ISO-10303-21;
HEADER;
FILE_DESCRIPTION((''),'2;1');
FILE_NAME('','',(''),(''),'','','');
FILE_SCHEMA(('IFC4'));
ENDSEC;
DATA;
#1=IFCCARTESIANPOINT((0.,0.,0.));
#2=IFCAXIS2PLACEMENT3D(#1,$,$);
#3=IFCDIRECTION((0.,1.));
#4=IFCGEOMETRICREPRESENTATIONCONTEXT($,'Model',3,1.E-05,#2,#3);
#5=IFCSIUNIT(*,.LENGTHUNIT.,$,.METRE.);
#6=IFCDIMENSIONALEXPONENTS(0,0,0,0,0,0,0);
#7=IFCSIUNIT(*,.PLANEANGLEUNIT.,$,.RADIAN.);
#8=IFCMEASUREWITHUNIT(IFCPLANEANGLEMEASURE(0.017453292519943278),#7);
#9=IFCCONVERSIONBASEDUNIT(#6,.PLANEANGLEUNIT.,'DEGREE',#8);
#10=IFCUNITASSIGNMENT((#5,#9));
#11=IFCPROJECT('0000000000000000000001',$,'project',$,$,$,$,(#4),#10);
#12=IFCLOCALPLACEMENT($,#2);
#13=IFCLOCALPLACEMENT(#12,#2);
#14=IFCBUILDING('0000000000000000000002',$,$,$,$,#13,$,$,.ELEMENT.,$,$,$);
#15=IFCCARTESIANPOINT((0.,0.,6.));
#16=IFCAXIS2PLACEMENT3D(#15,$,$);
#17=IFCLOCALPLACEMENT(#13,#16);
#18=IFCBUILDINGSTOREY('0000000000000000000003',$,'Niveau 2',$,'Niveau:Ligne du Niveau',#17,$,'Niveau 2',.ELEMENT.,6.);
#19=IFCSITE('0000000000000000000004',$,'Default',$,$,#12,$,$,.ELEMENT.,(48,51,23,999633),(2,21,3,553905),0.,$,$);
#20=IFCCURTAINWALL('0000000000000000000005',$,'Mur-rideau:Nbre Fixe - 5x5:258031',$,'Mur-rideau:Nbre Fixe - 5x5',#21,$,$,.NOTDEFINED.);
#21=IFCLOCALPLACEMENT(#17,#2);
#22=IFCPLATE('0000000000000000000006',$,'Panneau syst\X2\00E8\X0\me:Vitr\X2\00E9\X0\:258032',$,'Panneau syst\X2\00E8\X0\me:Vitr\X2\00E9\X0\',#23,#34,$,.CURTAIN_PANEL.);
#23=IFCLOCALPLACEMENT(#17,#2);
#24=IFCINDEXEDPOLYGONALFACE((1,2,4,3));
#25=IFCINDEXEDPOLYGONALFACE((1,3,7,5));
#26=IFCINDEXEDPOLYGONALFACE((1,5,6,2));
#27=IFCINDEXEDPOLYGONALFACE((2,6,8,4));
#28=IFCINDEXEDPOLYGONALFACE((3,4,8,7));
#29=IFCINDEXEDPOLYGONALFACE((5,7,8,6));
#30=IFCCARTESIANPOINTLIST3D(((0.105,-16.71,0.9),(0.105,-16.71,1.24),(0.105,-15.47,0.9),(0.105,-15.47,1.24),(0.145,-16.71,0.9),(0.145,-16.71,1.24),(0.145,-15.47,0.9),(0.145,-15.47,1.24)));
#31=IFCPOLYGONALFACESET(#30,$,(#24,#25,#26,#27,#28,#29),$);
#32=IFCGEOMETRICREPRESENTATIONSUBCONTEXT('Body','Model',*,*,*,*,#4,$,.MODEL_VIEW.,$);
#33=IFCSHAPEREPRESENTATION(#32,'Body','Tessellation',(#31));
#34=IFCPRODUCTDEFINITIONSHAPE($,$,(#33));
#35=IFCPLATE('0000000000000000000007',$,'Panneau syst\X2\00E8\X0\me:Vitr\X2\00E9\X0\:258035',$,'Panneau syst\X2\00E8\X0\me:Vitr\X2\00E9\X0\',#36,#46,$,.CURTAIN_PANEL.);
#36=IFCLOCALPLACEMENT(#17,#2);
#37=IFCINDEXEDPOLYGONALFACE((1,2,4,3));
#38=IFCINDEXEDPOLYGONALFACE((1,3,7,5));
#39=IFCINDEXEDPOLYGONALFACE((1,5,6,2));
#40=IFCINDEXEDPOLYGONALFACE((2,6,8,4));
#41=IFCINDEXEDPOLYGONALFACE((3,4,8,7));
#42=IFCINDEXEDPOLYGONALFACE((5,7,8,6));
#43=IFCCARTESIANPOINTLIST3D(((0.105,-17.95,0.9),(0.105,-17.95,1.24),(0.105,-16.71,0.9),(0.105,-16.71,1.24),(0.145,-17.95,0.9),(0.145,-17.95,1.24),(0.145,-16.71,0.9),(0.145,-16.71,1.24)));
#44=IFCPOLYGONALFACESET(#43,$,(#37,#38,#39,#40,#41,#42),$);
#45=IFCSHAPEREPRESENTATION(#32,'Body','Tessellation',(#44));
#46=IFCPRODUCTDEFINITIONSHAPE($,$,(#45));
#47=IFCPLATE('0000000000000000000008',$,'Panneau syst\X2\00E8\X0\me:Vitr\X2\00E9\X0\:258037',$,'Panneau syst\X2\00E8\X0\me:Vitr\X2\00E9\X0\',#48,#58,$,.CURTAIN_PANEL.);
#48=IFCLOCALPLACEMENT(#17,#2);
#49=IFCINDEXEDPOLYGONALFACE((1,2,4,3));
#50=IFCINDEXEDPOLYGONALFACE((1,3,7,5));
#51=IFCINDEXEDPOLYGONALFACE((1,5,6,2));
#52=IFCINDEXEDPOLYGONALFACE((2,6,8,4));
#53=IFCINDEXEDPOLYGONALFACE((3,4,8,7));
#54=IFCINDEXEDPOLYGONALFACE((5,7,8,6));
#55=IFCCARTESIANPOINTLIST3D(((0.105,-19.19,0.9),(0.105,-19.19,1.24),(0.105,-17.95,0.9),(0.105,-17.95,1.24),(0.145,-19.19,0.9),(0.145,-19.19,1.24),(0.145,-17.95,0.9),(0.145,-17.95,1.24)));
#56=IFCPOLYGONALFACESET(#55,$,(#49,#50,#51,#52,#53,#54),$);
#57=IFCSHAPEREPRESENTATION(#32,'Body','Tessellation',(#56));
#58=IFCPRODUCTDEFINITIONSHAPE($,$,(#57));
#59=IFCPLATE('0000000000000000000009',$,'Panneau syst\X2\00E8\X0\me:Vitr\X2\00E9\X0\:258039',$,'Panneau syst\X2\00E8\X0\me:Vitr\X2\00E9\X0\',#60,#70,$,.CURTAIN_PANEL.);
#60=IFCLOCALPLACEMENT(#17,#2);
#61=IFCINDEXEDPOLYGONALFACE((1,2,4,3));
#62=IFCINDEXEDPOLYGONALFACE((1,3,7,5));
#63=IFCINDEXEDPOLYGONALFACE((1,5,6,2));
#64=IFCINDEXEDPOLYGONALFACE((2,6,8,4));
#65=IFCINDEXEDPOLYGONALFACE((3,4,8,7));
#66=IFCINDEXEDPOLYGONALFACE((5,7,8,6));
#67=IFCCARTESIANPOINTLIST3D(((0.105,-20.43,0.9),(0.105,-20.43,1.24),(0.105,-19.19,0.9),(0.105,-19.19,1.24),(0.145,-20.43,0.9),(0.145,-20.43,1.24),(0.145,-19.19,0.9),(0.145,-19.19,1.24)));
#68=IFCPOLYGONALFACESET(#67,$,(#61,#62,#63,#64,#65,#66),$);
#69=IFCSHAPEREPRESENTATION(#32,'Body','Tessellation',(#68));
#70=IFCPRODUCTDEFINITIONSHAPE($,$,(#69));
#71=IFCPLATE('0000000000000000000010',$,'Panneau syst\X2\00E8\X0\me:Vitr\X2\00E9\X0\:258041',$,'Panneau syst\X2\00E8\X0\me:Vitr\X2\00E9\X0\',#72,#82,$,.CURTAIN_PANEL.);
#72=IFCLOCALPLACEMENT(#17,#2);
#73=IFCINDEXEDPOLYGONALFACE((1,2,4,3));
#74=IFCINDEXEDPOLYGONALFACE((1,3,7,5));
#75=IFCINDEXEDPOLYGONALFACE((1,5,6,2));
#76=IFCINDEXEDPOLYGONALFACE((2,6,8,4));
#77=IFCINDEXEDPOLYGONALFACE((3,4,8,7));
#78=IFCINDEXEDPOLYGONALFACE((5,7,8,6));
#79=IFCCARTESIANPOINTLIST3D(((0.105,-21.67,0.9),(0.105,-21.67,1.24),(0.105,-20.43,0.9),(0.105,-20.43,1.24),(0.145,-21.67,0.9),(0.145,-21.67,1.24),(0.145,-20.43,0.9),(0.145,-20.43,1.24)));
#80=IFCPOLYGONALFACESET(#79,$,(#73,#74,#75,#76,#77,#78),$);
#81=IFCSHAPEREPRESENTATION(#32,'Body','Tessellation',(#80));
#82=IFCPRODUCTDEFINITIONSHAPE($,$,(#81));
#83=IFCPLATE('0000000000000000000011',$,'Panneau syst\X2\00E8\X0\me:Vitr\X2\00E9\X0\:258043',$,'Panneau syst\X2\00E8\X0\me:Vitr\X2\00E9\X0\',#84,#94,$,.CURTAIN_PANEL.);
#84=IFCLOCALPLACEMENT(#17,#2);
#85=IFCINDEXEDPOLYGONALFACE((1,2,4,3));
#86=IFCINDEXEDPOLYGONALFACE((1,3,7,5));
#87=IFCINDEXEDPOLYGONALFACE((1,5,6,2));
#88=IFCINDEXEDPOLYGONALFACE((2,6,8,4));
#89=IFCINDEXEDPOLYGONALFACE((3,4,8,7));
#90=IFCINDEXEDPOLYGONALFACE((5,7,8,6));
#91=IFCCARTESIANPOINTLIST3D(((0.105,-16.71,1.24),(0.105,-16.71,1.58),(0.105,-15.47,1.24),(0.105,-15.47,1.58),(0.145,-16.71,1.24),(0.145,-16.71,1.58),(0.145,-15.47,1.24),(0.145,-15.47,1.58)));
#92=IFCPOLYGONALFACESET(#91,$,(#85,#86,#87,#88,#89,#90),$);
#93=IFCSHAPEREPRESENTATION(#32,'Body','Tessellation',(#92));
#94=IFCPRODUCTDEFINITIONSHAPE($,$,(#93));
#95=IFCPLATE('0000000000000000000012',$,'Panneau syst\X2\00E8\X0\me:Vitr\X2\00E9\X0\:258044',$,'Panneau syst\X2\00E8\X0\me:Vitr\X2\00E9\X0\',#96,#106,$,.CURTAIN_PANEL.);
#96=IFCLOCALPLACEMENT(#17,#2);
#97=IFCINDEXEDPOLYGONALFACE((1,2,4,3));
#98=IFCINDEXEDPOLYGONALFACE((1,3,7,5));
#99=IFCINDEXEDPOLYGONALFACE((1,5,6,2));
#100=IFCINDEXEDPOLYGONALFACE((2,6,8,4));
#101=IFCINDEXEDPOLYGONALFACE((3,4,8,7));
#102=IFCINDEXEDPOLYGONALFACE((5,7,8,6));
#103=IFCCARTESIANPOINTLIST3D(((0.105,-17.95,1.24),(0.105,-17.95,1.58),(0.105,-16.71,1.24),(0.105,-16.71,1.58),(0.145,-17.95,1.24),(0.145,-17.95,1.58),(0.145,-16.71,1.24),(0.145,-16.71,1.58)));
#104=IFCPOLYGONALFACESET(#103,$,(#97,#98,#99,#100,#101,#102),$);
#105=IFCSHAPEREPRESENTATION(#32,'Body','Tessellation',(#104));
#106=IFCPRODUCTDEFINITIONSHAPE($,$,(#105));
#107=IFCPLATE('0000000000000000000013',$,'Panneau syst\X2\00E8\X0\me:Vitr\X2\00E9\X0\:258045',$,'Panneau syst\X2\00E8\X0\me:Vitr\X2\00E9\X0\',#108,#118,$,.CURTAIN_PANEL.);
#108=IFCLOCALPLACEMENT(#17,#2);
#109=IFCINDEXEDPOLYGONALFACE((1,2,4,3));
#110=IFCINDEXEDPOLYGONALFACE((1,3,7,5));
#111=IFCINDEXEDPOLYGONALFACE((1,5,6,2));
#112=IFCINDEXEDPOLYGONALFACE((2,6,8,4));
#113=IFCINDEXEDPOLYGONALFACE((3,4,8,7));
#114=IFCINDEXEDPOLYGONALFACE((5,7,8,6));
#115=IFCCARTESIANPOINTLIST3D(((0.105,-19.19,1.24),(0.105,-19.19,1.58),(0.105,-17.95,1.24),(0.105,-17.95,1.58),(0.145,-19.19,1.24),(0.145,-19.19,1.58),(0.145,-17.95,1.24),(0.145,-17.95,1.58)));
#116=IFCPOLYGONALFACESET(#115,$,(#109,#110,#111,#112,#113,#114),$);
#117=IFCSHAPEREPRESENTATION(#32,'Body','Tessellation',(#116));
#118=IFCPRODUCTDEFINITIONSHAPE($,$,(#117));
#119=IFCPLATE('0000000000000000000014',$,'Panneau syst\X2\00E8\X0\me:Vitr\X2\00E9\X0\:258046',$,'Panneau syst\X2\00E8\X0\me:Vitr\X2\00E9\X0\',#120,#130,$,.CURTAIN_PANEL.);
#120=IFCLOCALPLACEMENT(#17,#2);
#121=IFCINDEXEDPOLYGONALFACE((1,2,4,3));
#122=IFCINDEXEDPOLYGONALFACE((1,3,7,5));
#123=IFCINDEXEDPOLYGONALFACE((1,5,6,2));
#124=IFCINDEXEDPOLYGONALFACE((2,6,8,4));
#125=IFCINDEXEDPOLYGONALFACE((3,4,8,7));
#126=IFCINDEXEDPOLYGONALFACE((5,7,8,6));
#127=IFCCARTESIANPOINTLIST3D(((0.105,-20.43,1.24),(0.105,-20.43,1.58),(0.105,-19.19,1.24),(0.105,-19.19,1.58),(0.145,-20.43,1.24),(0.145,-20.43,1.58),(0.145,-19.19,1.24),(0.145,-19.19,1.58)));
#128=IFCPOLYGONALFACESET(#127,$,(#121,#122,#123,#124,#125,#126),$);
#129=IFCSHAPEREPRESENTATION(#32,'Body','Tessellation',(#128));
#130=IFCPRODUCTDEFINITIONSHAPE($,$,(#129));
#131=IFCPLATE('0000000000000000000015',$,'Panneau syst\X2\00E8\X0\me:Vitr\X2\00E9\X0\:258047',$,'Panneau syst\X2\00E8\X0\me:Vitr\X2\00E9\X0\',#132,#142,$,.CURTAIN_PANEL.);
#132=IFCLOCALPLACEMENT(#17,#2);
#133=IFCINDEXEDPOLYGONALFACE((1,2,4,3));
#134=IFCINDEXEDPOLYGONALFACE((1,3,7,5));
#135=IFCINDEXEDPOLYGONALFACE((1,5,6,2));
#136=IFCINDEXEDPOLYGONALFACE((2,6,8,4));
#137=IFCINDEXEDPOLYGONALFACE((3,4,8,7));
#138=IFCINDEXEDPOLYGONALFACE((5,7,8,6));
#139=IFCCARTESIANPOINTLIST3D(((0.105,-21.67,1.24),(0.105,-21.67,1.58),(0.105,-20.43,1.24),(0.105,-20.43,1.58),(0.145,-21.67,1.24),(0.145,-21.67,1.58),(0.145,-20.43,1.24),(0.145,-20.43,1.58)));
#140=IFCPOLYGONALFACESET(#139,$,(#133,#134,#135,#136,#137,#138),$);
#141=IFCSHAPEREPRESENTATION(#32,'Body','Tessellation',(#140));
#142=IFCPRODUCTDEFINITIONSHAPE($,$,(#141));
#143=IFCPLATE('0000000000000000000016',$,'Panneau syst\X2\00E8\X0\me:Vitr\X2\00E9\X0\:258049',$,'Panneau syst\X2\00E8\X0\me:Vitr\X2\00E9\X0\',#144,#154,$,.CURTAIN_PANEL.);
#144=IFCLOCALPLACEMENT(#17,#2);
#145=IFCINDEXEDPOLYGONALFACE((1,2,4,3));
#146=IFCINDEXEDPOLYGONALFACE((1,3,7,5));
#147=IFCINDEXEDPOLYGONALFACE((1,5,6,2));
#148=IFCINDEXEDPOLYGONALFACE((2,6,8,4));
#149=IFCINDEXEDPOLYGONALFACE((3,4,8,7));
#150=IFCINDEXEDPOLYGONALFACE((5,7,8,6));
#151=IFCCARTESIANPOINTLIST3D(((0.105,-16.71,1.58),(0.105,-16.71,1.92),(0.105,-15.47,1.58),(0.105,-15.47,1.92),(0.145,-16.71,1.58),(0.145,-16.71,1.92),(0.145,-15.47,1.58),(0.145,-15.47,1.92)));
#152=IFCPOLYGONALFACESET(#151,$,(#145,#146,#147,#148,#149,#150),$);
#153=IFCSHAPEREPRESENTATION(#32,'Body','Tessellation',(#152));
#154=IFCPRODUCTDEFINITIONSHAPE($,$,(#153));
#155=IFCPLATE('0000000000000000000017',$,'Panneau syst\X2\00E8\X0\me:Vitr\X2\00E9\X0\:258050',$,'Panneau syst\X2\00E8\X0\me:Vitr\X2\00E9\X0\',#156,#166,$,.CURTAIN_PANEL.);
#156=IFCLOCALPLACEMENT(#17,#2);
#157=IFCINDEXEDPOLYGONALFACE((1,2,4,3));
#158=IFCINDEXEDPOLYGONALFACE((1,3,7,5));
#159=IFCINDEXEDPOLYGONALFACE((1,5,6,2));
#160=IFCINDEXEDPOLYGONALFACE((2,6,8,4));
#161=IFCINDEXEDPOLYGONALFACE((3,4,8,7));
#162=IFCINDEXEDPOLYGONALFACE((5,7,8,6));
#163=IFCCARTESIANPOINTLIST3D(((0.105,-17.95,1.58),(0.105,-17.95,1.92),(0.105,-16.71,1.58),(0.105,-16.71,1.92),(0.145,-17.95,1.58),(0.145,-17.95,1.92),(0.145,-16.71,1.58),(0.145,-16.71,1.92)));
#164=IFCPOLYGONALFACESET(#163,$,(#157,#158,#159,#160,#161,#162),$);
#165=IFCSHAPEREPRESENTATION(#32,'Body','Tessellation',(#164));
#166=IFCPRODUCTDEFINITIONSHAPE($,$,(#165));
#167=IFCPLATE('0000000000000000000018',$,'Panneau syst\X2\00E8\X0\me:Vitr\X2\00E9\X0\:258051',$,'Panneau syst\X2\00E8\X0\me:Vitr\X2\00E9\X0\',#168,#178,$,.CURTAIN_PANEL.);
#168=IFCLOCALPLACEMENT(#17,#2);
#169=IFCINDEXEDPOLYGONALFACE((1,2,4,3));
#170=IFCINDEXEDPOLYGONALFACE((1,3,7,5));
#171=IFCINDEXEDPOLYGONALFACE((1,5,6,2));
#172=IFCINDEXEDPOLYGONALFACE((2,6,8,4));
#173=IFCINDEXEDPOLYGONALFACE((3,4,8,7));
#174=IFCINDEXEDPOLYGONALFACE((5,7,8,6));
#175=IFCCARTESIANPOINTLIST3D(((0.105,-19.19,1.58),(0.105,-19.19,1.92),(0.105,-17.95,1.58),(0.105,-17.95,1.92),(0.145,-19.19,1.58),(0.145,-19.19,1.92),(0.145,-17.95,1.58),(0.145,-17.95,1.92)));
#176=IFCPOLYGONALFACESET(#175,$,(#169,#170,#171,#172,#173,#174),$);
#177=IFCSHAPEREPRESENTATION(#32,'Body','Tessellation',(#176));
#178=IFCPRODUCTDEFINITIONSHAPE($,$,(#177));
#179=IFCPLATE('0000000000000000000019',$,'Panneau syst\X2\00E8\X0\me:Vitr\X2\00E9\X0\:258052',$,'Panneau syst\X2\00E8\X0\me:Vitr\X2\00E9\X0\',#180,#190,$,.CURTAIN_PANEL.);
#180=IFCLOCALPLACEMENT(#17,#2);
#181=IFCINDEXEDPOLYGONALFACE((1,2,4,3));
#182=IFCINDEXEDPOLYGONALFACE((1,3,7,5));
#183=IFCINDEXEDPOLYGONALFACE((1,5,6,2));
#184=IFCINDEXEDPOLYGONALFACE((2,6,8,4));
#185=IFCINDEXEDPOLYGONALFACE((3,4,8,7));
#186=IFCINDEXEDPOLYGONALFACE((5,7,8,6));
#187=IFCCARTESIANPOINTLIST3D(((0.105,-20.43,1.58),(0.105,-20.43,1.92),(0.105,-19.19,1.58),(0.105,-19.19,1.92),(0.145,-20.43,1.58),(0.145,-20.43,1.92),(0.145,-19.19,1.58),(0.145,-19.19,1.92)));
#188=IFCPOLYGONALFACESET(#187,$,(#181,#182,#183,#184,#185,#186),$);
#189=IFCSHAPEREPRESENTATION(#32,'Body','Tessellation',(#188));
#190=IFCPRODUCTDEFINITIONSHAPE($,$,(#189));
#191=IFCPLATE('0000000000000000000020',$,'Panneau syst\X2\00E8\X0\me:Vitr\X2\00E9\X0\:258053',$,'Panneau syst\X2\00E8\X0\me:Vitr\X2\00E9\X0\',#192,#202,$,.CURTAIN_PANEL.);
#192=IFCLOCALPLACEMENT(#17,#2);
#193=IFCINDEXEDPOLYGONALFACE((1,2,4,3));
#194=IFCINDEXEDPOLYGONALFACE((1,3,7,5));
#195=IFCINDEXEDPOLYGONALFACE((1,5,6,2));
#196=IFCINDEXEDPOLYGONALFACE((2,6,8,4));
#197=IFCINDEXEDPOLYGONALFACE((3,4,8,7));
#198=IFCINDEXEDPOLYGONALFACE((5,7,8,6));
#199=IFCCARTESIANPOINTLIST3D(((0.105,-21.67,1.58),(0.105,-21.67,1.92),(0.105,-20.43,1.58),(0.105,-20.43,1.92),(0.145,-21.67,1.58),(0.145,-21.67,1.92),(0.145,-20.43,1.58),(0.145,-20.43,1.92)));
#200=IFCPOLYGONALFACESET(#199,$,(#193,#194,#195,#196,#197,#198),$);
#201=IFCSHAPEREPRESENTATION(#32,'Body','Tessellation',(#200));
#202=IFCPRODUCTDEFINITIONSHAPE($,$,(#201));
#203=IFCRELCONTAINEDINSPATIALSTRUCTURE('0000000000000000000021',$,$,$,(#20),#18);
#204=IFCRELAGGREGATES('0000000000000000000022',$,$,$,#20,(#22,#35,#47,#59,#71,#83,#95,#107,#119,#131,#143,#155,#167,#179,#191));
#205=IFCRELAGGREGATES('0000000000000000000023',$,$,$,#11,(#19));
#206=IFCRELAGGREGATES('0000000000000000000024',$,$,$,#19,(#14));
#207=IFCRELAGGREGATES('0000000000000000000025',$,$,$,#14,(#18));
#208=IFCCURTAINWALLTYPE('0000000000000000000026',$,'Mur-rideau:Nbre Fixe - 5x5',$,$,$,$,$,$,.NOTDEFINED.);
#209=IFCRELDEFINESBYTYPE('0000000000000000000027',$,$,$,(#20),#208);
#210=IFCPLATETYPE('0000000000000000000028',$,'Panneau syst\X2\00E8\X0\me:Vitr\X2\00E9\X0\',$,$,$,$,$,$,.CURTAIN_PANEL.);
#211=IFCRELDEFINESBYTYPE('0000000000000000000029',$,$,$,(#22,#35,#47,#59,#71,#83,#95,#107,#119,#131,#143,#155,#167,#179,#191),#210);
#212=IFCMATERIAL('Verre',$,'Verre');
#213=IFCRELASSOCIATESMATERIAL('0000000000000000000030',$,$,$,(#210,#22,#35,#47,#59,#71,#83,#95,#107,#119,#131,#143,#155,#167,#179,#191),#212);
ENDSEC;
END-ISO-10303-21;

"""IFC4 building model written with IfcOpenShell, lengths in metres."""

from ifc_helpers import new_model, entity, si_unit, converted_unit, direction, frame, origin, place, context, subcontext, project, spatial, indexed_curve, outline, extrude, source, transform, mapped, material, type_object, type_shapes, element, aggregate, save


model = new_model("IFC4")

# Units and contexts
model_context = context("Model", 3, precision=1e-05, world=origin(), true_north=direction((0.0, 1.0)))
body_context = subcontext(model_context, "Body", "Model", "MODEL_VIEW")
ifc_project = project(units=[si_unit("LENGTHUNIT", "METRE"), converted_unit("PLANEANGLEUNIT", "DEGREE", entity("IfcPlaneAngleMeasure", 0.017453292519943278), si_unit("PLANEANGLEUNIT", "RADIAN"), dimensions=[0, 0, 0, 0, 0, 0, 0])], contexts=[model_context])

# Site, building, storey
site_placement = place(None, origin())
site = spatial("IfcSite", under=ifc_project, at=site_placement, Name="Default", CompositionType="ELEMENT", RefLatitude=(48, 51, 23, 999633), RefLongitude=(2, 21, 3, 553905), RefElevation=0.0)
building_placement = place(site_placement, origin())
building = spatial("IfcBuilding", under=site, at=building_placement, CompositionType="ELEMENT")
storey_placement = place(building_placement, frame((0.0, 0.0, 6.0)))
storey = spatial("IfcBuildingStorey", under=building, at=storey_placement, Name="Niveau 2", ObjectType="Niveau:Ligne du Niveau", LongName="Niveau 2", CompositionType="ELEMENT", Elevation=6.0)

# Curtain wall, plates
curtain_wall_type = type_object("IfcCurtainWallType", Name="Mur-rideau:Nbre Fixe - 5x5", PredefinedType="NOTDEFINED")
curtain_wall_placement = place(storey_placement, frame((0.0, 0.0, -6.0)))
curtain_wall = element("IfcCurtainWall", 1, at=curtain_wall_placement, inside=storey, type_object=curtain_wall_type, Name="Mur-rideau:Nbre Fixe - 5x5:258031", ObjectType="Mur-rideau:Nbre Fixe - 5x5", PredefinedType="NOTDEFINED")
ifc_material_1 = material(Name="Verre", Category="Verre")
plate_type = type_object("IfcPlateType", Name="Panneau système:Vitré", PredefinedType="CURTAIN_PANEL", material=ifc_material_1)
shared_shape = source(origin(), body_context, "Body", "SweptSolid", [
    extrude(outline(indexed_curve([(-0.02, -0.62), (0.02, -0.62), (0.02, 0.62), (-0.02, 0.62), (-0.02, -0.62)], self_intersect=False)), frame((0.62, 0.02, 0.0), z_axis=(0.0, 0.0, 1.0), x_axis=(0.0, 1.0, 0.0)), (0.0, 0.0, 1.0), 0.34),
])
type_shapes(plate_type, [shared_shape])
plate_1_placement = place(curtain_wall_placement, frame((0.105, -15.47, 6.9), z_axis=(0.0, 0.0, 1.0), x_axis=(0.0, -1.0, 0.0)))
plate_1 = element("IfcPlate", 2, at=plate_1_placement, type_object=plate_type, material=ifc_material_1, Name="Panneau système:Vitré:258032", ObjectType="Panneau système:Vitré", PredefinedType="CURTAIN_PANEL", context=body_context, shape_type="MappedRepresentation", body=[
    mapped(shared_shape, transform((0.0, 0.0, 0.0), scale=1.0)),
])
plate_2_placement = place(curtain_wall_placement, frame((0.105, -16.71, 6.9), z_axis=(0.0, 0.0, 1.0), x_axis=(0.0, -1.0, 0.0)))
plate_2 = element("IfcPlate", 3, at=plate_2_placement, type_object=plate_type, material=ifc_material_1, Name="Panneau système:Vitré:258035", ObjectType="Panneau système:Vitré", PredefinedType="CURTAIN_PANEL", context=body_context, shape_type="MappedRepresentation", body=[
    mapped(shared_shape, transform((0.0, 0.0, 0.0), scale=1.0)),
])
plate_3_placement = place(curtain_wall_placement, frame((0.105, -17.95, 6.9), z_axis=(0.0, 0.0, 1.0), x_axis=(0.0, -1.0, 0.0)))
plate_3 = element("IfcPlate", 4, at=plate_3_placement, type_object=plate_type, material=ifc_material_1, Name="Panneau système:Vitré:258037", ObjectType="Panneau système:Vitré", PredefinedType="CURTAIN_PANEL", context=body_context, shape_type="MappedRepresentation", body=[
    mapped(shared_shape, transform((0.0, 0.0, 0.0), scale=1.0)),
])
plate_4_placement = place(curtain_wall_placement, frame((0.105, -19.19, 6.9), z_axis=(0.0, 0.0, 1.0), x_axis=(0.0, -1.0, 0.0)))
plate_4 = element("IfcPlate", 5, at=plate_4_placement, type_object=plate_type, material=ifc_material_1, Name="Panneau système:Vitré:258039", ObjectType="Panneau système:Vitré", PredefinedType="CURTAIN_PANEL", context=body_context, shape_type="MappedRepresentation", body=[
    mapped(shared_shape, transform((0.0, 0.0, 0.0), scale=1.0)),
])
plate_5_placement = place(curtain_wall_placement, frame((0.105, -20.43, 6.9), z_axis=(0.0, 0.0, 1.0), x_axis=(0.0, -1.0, 0.0)))
plate_5 = element("IfcPlate", 6, at=plate_5_placement, type_object=plate_type, material=ifc_material_1, Name="Panneau système:Vitré:258041", ObjectType="Panneau système:Vitré", PredefinedType="CURTAIN_PANEL", context=body_context, shape_type="MappedRepresentation", body=[
    mapped(shared_shape, transform((0.0, 0.0, 0.0), scale=1.0)),
])
plate_6_placement = place(curtain_wall_placement, frame((0.105, -15.47, 7.24), z_axis=(0.0, 0.0, 1.0), x_axis=(0.0, -1.0, 0.0)))
plate_6 = element("IfcPlate", 7, at=plate_6_placement, type_object=plate_type, material=ifc_material_1, Name="Panneau système:Vitré:258043", ObjectType="Panneau système:Vitré", PredefinedType="CURTAIN_PANEL", context=body_context, shape_type="MappedRepresentation", body=[
    mapped(shared_shape, transform((0.0, 0.0, 0.0), scale=1.0)),
])
plate_7_placement = place(curtain_wall_placement, frame((0.105, -16.71, 7.24), z_axis=(0.0, 0.0, 1.0), x_axis=(0.0, -1.0, 0.0)))
plate_7 = element("IfcPlate", 8, at=plate_7_placement, type_object=plate_type, material=ifc_material_1, Name="Panneau système:Vitré:258044", ObjectType="Panneau système:Vitré", PredefinedType="CURTAIN_PANEL", context=body_context, shape_type="MappedRepresentation", body=[
    mapped(shared_shape, transform((0.0, 0.0, 0.0), scale=1.0)),
])
plate_8_placement = place(curtain_wall_placement, frame((0.105, -17.95, 7.24), z_axis=(0.0, 0.0, 1.0), x_axis=(0.0, -1.0, 0.0)))
plate_8 = element("IfcPlate", 9, at=plate_8_placement, type_object=plate_type, material=ifc_material_1, Name="Panneau système:Vitré:258045", ObjectType="Panneau système:Vitré", PredefinedType="CURTAIN_PANEL", context=body_context, shape_type="MappedRepresentation", body=[
    mapped(shared_shape, transform((0.0, 0.0, 0.0), scale=1.0)),
])
plate_9_placement = place(curtain_wall_placement, frame((0.105, -19.19, 7.24), z_axis=(0.0, 0.0, 1.0), x_axis=(0.0, -1.0, 0.0)))
plate_9 = element("IfcPlate", 10, at=plate_9_placement, type_object=plate_type, material=ifc_material_1, Name="Panneau système:Vitré:258046", ObjectType="Panneau système:Vitré", PredefinedType="CURTAIN_PANEL", context=body_context, shape_type="MappedRepresentation", body=[
    mapped(shared_shape, transform((0.0, 0.0, 0.0), scale=1.0)),
])
plate_10_placement = place(curtain_wall_placement, frame((0.105, -20.43, 7.24), z_axis=(0.0, 0.0, 1.0), x_axis=(0.0, -1.0, 0.0)))
plate_10 = element("IfcPlate", 11, at=plate_10_placement, type_object=plate_type, material=ifc_material_1, Name="Panneau système:Vitré:258047", ObjectType="Panneau système:Vitré", PredefinedType="CURTAIN_PANEL", context=body_context, shape_type="MappedRepresentation", body=[
    mapped(shared_shape, transform((0.0, 0.0, 0.0), scale=1.0)),
])
plate_11_placement = place(curtain_wall_placement, frame((0.105, -15.47, 7.58), z_axis=(0.0, 0.0, 1.0), x_axis=(0.0, -1.0, 0.0)))
plate_11 = element("IfcPlate", 12, at=plate_11_placement, type_object=plate_type, material=ifc_material_1, Name="Panneau système:Vitré:258049", ObjectType="Panneau système:Vitré", PredefinedType="CURTAIN_PANEL", context=body_context, shape_type="MappedRepresentation", body=[
    mapped(shared_shape, transform((0.0, 0.0, 0.0), scale=1.0)),
])
plate_12_placement = place(curtain_wall_placement, frame((0.105, -16.71, 7.58), z_axis=(0.0, 0.0, 1.0), x_axis=(0.0, -1.0, 0.0)))
plate_12 = element("IfcPlate", 13, at=plate_12_placement, type_object=plate_type, material=ifc_material_1, Name="Panneau système:Vitré:258050", ObjectType="Panneau système:Vitré", PredefinedType="CURTAIN_PANEL", context=body_context, shape_type="MappedRepresentation", body=[
    mapped(shared_shape, transform((0.0, 0.0, 0.0), scale=1.0)),
])
plate_13_placement = place(curtain_wall_placement, frame((0.105, -17.95, 7.58), z_axis=(0.0, 0.0, 1.0), x_axis=(0.0, -1.0, 0.0)))
plate_13 = element("IfcPlate", 14, at=plate_13_placement, type_object=plate_type, material=ifc_material_1, Name="Panneau système:Vitré:258051", ObjectType="Panneau système:Vitré", PredefinedType="CURTAIN_PANEL", context=body_context, shape_type="MappedRepresentation", body=[
    mapped(shared_shape, transform((0.0, 0.0, 0.0), scale=1.0)),
])
plate_14_placement = place(curtain_wall_placement, frame((0.105, -19.19, 7.58), z_axis=(0.0, 0.0, 1.0), x_axis=(0.0, -1.0, 0.0)))
plate_14 = element("IfcPlate", 15, at=plate_14_placement, type_object=plate_type, material=ifc_material_1, Name="Panneau système:Vitré:258052", ObjectType="Panneau système:Vitré", PredefinedType="CURTAIN_PANEL", context=body_context, shape_type="MappedRepresentation", body=[
    mapped(shared_shape, transform((0.0, 0.0, 0.0), scale=1.0)),
])
plate_15_placement = place(curtain_wall_placement, frame((0.105, -20.43, 7.58), z_axis=(0.0, 0.0, 1.0), x_axis=(0.0, -1.0, 0.0)))
plate_15 = element("IfcPlate", 16, at=plate_15_placement, type_object=plate_type, material=ifc_material_1, Name="Panneau système:Vitré:258053", ObjectType="Panneau système:Vitré", PredefinedType="CURTAIN_PANEL", context=body_context, shape_type="MappedRepresentation", body=[
    mapped(shared_shape, transform((0.0, 0.0, 0.0), scale=1.0)),
])
aggregate(curtain_wall, [plate_1, plate_2, plate_3, plate_4, plate_5, plate_6, plate_7, plate_8, plate_9, plate_10, plate_11, plate_12, plate_13, plate_14, plate_15])

save(model, "model.ifc")
